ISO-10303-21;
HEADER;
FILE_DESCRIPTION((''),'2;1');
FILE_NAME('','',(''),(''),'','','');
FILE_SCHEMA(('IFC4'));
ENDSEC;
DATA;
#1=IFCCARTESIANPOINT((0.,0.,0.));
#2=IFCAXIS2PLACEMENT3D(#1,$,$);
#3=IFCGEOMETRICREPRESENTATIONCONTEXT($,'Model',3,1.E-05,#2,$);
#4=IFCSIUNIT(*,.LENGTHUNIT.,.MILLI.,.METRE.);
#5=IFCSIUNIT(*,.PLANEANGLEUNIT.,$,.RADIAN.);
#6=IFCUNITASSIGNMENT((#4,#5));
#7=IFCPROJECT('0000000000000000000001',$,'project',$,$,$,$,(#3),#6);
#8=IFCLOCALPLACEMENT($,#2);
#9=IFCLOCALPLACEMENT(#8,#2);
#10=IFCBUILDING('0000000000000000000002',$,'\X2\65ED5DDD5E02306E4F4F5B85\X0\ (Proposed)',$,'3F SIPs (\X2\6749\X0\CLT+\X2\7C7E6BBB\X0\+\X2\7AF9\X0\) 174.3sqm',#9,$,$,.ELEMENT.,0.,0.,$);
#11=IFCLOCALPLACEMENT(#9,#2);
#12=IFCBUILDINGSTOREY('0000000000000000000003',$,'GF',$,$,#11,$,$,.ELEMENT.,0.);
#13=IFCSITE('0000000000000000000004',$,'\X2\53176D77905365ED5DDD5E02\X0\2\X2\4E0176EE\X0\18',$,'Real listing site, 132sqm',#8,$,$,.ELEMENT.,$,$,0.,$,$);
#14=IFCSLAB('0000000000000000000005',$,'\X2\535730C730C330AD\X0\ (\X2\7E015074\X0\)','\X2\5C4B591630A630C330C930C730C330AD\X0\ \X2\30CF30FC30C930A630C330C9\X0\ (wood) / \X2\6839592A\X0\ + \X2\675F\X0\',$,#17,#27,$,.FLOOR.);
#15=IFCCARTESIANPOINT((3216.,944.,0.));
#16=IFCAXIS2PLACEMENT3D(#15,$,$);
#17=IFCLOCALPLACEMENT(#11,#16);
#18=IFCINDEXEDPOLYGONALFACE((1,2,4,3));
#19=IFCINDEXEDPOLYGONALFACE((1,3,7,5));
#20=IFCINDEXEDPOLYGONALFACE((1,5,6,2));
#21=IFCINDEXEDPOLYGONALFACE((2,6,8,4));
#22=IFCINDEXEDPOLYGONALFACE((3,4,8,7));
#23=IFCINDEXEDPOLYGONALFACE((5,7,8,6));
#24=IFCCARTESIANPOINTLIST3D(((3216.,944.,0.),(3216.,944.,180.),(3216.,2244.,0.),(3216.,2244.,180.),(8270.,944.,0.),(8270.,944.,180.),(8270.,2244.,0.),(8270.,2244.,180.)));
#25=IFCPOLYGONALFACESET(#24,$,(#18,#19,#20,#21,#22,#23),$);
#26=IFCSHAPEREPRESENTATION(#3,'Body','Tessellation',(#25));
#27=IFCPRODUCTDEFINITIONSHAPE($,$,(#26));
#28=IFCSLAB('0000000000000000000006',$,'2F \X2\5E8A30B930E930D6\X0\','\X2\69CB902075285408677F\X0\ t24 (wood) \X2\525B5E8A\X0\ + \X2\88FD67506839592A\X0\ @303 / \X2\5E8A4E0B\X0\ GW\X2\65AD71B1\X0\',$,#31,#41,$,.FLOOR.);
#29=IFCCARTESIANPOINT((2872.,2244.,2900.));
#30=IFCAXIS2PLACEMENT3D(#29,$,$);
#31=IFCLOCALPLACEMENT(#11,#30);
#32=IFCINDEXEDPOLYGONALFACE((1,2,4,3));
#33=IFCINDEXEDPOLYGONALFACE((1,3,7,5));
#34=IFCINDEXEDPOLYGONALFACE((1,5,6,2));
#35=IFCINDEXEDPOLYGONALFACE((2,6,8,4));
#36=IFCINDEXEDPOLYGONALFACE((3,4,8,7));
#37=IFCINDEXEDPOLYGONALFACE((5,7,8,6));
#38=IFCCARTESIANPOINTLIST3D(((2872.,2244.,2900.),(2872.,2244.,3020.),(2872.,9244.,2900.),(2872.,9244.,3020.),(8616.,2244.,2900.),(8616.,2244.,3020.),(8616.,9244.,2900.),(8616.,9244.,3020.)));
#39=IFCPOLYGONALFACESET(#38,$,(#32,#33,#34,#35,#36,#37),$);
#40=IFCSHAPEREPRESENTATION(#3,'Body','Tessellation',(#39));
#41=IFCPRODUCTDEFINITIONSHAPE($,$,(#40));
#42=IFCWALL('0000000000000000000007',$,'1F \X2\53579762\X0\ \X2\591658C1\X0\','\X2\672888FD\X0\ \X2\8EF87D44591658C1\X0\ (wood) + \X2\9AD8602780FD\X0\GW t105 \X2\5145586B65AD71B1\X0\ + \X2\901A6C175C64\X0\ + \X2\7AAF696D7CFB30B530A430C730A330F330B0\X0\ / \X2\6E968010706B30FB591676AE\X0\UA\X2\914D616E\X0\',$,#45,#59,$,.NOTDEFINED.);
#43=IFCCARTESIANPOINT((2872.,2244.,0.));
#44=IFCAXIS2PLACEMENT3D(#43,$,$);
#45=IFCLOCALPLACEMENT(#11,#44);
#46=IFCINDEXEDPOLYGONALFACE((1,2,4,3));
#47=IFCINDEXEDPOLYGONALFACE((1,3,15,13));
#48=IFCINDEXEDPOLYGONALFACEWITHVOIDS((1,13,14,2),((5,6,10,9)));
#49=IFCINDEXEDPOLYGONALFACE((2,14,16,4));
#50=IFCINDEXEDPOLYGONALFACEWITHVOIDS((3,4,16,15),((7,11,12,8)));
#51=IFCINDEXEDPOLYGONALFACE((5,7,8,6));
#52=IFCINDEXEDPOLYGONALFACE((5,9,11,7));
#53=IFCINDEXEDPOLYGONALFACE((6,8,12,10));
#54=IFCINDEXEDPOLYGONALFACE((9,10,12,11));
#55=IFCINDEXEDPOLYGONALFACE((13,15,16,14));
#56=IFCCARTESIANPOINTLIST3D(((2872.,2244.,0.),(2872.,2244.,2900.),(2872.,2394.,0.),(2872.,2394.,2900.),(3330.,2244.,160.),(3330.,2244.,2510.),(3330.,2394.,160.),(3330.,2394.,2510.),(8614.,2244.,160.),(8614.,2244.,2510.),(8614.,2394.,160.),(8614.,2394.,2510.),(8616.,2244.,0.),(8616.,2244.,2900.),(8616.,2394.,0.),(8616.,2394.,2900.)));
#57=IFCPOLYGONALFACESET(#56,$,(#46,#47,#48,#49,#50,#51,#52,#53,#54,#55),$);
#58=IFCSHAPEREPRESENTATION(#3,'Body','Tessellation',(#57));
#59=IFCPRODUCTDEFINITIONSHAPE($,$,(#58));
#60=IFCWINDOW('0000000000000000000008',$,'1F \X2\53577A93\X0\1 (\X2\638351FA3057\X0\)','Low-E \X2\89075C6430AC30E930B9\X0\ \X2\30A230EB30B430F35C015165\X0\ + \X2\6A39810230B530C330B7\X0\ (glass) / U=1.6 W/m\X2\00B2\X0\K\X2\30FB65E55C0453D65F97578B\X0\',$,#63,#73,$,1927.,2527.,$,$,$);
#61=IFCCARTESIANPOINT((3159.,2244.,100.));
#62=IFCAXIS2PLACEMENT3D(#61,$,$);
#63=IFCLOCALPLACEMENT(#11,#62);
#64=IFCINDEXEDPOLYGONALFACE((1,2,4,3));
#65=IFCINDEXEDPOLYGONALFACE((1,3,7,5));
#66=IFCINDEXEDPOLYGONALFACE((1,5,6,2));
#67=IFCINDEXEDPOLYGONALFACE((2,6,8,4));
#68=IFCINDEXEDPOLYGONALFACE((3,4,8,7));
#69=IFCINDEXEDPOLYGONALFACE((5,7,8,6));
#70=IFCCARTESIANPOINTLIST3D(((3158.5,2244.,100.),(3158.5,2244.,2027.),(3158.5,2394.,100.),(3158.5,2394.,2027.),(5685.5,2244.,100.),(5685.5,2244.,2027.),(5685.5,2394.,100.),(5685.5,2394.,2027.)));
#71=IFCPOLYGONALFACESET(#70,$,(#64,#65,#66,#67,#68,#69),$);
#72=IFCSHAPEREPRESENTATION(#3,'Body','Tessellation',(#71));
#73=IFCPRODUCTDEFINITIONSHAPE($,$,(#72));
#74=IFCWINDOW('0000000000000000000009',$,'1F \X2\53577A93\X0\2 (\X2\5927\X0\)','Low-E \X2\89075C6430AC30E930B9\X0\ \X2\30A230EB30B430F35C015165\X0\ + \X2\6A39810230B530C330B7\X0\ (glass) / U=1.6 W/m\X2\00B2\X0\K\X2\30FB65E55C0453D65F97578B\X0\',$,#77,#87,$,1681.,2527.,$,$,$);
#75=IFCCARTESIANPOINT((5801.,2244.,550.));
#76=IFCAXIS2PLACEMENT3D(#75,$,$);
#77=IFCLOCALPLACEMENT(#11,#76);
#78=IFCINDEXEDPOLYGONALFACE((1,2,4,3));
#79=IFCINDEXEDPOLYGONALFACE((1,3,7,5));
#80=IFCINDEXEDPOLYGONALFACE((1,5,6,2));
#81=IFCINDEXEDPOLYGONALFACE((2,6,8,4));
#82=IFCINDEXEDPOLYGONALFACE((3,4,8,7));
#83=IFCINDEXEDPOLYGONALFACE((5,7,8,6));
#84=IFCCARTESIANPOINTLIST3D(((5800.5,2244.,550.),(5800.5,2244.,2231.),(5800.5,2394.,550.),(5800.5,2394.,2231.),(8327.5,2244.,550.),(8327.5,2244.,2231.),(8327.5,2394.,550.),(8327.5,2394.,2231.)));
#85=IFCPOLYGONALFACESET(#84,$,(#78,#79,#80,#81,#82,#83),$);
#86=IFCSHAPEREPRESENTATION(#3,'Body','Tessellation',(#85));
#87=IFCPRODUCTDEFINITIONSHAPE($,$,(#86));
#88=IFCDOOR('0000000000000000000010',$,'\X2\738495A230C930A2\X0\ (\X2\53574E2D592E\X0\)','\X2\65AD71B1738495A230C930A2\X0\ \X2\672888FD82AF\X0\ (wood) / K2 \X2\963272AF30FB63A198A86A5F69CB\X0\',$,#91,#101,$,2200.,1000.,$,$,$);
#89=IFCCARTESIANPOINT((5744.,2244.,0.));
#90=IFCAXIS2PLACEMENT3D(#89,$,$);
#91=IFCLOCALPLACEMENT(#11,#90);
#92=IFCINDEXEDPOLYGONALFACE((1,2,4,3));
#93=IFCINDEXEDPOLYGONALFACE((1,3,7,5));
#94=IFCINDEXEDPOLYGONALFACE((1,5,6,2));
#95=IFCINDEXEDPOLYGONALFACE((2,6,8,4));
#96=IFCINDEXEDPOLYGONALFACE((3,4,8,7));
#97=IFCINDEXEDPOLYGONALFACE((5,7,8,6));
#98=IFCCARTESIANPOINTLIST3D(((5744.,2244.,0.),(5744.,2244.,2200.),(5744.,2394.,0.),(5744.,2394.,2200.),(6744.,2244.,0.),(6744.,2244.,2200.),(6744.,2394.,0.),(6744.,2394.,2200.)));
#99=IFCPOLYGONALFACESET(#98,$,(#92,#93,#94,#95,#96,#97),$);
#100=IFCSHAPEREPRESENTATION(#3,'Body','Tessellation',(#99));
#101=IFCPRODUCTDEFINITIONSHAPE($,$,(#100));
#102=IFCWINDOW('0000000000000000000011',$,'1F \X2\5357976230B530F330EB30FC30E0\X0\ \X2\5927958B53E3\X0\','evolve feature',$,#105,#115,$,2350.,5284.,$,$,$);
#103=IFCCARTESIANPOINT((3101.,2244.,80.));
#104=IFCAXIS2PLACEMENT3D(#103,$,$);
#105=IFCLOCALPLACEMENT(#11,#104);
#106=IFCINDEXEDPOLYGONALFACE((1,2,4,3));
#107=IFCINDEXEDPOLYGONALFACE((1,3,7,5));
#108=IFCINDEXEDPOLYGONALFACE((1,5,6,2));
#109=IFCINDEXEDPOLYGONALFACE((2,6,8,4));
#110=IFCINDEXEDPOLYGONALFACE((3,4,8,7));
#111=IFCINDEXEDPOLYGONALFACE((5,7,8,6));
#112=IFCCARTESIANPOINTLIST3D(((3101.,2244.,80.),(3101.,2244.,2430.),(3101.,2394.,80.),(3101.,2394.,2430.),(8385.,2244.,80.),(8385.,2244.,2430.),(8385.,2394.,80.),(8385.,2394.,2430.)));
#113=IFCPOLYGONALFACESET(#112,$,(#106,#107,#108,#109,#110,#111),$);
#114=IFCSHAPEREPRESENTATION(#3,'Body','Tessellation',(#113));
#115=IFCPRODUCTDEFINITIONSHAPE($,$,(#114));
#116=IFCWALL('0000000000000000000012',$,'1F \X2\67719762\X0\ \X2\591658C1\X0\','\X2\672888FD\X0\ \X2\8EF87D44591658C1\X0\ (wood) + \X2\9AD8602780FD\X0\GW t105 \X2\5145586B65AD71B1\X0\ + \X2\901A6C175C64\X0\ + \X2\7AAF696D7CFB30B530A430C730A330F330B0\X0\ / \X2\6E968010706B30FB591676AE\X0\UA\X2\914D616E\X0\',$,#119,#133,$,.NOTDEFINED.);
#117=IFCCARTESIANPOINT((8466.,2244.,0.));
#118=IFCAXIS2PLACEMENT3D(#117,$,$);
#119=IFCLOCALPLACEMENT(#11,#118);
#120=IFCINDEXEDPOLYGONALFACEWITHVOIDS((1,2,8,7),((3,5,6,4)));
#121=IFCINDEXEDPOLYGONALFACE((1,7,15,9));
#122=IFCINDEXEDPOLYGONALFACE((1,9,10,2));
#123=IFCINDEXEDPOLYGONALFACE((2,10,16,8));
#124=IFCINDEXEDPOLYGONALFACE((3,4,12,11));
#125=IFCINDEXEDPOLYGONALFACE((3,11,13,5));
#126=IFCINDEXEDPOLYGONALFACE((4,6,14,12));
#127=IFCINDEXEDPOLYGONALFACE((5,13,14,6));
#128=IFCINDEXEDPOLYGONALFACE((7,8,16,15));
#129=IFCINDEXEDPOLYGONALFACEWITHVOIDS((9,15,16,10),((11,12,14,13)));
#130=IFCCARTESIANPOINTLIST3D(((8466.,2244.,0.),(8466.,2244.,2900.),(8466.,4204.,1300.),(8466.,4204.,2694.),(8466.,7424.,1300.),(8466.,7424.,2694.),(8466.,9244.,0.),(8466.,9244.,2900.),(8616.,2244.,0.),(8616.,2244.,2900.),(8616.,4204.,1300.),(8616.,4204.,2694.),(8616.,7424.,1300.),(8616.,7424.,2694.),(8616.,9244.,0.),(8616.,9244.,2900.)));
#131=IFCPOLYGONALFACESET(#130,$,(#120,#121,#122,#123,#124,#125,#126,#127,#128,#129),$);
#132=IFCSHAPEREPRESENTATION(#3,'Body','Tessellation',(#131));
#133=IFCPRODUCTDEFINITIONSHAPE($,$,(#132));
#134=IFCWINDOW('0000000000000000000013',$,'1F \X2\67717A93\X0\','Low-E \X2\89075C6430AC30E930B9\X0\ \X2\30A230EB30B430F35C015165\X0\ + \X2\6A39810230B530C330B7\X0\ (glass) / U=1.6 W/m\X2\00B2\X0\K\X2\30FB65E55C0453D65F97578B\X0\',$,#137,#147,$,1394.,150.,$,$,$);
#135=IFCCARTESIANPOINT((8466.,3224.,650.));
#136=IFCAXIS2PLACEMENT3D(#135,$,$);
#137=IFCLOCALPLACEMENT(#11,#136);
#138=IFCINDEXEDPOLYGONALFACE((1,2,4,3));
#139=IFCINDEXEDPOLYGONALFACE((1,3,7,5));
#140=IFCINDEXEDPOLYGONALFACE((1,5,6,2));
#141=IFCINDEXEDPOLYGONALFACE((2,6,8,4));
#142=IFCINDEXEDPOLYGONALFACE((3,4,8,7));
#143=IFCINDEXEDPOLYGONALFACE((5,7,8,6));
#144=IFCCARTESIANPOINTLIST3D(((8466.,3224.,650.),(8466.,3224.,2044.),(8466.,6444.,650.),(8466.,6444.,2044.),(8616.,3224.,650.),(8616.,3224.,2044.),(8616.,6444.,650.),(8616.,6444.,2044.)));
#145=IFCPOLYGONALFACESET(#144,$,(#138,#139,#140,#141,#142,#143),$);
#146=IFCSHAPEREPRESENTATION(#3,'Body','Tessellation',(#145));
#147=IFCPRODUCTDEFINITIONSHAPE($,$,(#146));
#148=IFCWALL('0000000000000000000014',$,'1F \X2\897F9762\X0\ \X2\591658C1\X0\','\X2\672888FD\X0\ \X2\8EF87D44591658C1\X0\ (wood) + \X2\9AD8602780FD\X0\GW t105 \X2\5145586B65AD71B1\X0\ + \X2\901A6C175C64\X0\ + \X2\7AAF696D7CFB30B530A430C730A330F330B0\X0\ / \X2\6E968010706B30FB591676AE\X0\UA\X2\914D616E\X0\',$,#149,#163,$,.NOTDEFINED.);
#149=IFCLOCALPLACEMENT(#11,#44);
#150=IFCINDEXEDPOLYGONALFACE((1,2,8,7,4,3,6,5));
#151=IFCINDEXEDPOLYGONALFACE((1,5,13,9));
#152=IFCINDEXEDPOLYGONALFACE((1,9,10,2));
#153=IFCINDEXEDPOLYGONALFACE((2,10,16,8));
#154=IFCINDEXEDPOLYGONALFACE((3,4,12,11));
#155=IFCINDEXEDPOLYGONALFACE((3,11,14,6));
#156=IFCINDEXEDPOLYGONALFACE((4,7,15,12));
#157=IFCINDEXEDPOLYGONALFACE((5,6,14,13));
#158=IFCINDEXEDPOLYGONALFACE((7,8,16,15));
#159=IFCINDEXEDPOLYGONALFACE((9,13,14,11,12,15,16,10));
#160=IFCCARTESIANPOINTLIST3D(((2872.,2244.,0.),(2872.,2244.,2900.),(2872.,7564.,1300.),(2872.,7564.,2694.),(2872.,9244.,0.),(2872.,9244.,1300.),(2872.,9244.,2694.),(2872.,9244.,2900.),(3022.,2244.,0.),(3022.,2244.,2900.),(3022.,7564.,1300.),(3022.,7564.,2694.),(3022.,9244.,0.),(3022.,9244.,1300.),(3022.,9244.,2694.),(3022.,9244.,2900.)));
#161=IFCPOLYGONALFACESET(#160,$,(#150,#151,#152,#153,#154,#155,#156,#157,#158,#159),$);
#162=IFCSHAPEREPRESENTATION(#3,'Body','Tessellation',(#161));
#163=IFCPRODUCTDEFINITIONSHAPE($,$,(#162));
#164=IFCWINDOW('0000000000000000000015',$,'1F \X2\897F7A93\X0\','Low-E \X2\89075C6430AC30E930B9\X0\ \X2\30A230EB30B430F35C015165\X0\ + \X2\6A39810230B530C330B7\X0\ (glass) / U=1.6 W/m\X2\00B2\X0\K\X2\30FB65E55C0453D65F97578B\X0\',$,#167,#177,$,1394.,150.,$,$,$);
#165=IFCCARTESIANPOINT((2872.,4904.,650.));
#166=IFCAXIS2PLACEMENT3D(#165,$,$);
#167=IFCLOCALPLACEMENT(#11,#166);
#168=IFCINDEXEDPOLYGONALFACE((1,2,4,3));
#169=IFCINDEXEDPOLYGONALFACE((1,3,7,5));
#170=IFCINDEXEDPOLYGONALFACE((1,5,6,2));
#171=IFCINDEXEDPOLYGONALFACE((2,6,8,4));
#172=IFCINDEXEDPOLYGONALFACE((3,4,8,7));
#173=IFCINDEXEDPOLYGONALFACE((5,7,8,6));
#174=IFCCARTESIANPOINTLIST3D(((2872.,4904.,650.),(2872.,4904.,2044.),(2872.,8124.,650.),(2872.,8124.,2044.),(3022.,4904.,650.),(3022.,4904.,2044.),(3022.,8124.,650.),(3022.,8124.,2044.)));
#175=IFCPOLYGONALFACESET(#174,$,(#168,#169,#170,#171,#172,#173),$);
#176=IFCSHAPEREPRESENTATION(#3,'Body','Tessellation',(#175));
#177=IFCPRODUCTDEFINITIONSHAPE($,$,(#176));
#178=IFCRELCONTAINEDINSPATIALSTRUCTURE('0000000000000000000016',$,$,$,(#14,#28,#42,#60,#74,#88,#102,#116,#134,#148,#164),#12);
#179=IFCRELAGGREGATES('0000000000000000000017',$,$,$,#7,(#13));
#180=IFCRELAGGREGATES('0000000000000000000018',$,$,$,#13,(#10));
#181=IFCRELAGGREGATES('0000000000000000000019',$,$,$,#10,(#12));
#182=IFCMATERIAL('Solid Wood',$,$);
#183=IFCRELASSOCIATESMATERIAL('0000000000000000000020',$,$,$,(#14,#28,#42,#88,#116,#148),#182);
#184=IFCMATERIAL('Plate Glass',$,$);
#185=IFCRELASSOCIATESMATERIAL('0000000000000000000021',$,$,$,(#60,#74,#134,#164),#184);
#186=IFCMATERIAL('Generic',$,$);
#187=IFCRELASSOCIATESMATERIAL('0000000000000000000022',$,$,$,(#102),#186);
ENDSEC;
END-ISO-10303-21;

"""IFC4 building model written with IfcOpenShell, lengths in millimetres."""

from ifc_helpers import new_model, si_unit, frame, frame_2d, origin, place, context, project, spatial, rectangle, extrude, material, element, fill, save


model = new_model("IFC4")

# Units and contexts
model_context = context("Model", 3, precision=1e-05, world=origin())
ifc_project = project(units=[si_unit("LENGTHUNIT", "METRE", prefix="MILLI"), si_unit("PLANEANGLEUNIT", "RADIAN")], contexts=[model_context])

# Site, building, storey
site_placement = place(None, origin())
site = spatial("IfcSite", under=ifc_project, at=site_placement, Name="北海道旭川市2丁目18", ObjectType="Real listing site, 132sqm", CompositionType="ELEMENT", RefElevation=0.0)
building_placement = place(site_placement, origin())
building = spatial("IfcBuilding", under=site, at=building_placement, Name="旭川市の住宅 (Proposed)", ObjectType="3F SIPs (杉CLT+籾殻+竹) 174.3sqm", CompositionType="ELEMENT", ElevationOfRefHeight=0.0, ElevationOfTerrain=0.0)
storey_placement = place(building_placement, origin())
storey = spatial("IfcBuildingStorey", under=building, at=storey_placement, Name="GF", CompositionType="ELEMENT", Elevation=0.0)

# Slabs
ifc_material_1 = material(Name="Solid Wood")
slab_1_placement = place(storey_placement, frame((3216.0, 944.0, 0.0)))
element("IfcSlab", 1, at=slab_1_placement, inside=storey, material=ifc_material_1, Name="南デッキ (縁側)", Description="屋外ウッドデッキ ハードウッド (wood) / 根太 + 束", PredefinedType="FLOOR", context=model_context, shape_type="SweptSolid", body=[
    extrude(rectangle(XDim=5054.0, YDim=1300.0, at=frame_2d((2527.0, 650.0))), frame((3216.0, 944.0, 0.0)), (0.0, 0.0, 1.0), 180.0),
])
slab_2_placement = place(storey_placement, frame((2872.0, 2244.0, 2900.0)))
element("IfcSlab", 2, at=slab_2_placement, inside=storey, material=ifc_material_1, Name="2F 床スラブ", Description="構造用合板 t24 (wood) 剛床 + 製材根太 @303 / 床下 GW断熱", PredefinedType="FLOOR", context=model_context, shape_type="SweptSolid", body=[
    extrude(rectangle(XDim=5744.0, YDim=7000.0, at=frame_2d((2872.0, 3500.0))), frame((2872.0, 2244.0, 2900.0)), (0.0, 0.0, 1.0), 120.0),
])
ifc_material_2 = material(Name="Generic")

# Wall, openings, windows, door
wall_1_placement = place(storey_placement, frame((2872.0, 2244.0, 0.0)))
wall_1 = element("IfcWall", 3, at=wall_1_placement, inside=storey, material=ifc_material_1, Name="1F 南面 外壁", Description="木製 軸組外壁 (wood) + 高性能GW t105 充填断熱 + 通気層 + 窯業系サイディング / 準耐火・外皮UA配慮", PredefinedType="NOTDEFINED", context=model_context, shape_type="SweptSolid", body=[
    extrude(rectangle(XDim=5744.0, YDim=150.0, at=frame_2d((2872.0, 75.0))), frame((2872.0, 2244.0, 0.0)), (0.0, 0.0, 1.0), 2900.0),
])
opening_1_placement = place(storey_placement, frame((3159.0, 2244.0, 100.0)))
opening_1 = element("IfcOpeningElement", 4, at=opening_1_placement, cuts=wall_1, PredefinedType="NOTDEFINED", context=model_context, shape_type="SweptSolid", body=[
    extrude(rectangle(XDim=2527.0, YDim=150.0, at=frame_2d((1263.0, 75.0))), frame((3159.0, 2244.0, 100.0)), (0.0, 0.0, 1.0), 1927.0),
])
opening_2_placement = place(storey_placement, frame((5801.0, 2244.0, 550.0)))
opening_2 = element("IfcOpeningElement", 5, at=opening_2_placement, cuts=wall_1, PredefinedType="NOTDEFINED", context=model_context, shape_type="SweptSolid", body=[
    extrude(rectangle(XDim=2527.0, YDim=150.0, at=frame_2d((1263.0, 75.0))), frame((5801.0, 2244.0, 550.0)), (0.0, 0.0, 1.0), 1681.0),
])
opening_3_placement = place(storey_placement, frame((5744.0, 2244.0, 0.0)))
opening_3 = element("IfcOpeningElement", 6, at=opening_3_placement, cuts=wall_1, PredefinedType="NOTDEFINED", context=model_context, shape_type="SweptSolid", body=[
    extrude(rectangle(XDim=1000.0, YDim=150.0, at=frame_2d((500.0, 75.0))), frame((5744.0, 2244.0, 0.0)), (0.0, 0.0, 1.0), 2200.0),
])
opening_4_placement = place(storey_placement, frame((3101.0, 2244.0, 80.0)))
opening_4 = element("IfcOpeningElement", 7, at=opening_4_placement, cuts=wall_1, PredefinedType="NOTDEFINED", context=model_context, shape_type="SweptSolid", body=[
    extrude(rectangle(XDim=5284.0, YDim=150.0, at=frame_2d((2642.0, 75.0))), frame((3101.0, 2244.0, 80.0)), (0.0, 0.0, 1.0), 2350.0),
])
ifc_material_3 = material(Name="Plate Glass")
window_1_placement = place(storey_placement, frame((3159.0, 2244.0, 100.0)))
window_1 = element("IfcWindow", 8, at=window_1_placement, inside=storey, material=ifc_material_3, Name="1F 南窓1 (掃出し)", Description="Low-E 複層ガラス アルゴン封入 + 樹脂サッシ (glass) / U=1.6 W/m²K・日射取得型", OverallHeight=1927.0, OverallWidth=2527.0, context=model_context, shape_type="SweptSolid", body=[
    extrude(rectangle(XDim=2527.0, YDim=150.0, at=frame_2d((1263.0, 75.0))), frame((3159.0, 2244.0, 100.0)), (0.0, 0.0, 1.0), 1927.0),
])
fill(opening_1, window_1)
window_2_placement = place(storey_placement, frame((5801.0, 2244.0, 550.0)))
window_2 = element("IfcWindow", 9, at=window_2_placement, inside=storey, material=ifc_material_3, Name="1F 南窓2 (大)", Description="Low-E 複層ガラス アルゴン封入 + 樹脂サッシ (glass) / U=1.6 W/m²K・日射取得型", OverallHeight=1681.0, OverallWidth=2527.0, context=model_context, shape_type="SweptSolid", body=[
    extrude(rectangle(XDim=2527.0, YDim=150.0, at=frame_2d((1263.0, 75.0))), frame((5801.0, 2244.0, 550.0)), (0.0, 0.0, 1.0), 1681.0),
])
fill(opening_2, window_2)
door_placement = place(storey_placement, frame((5744.0, 2244.0, 0.0)))
door = element("IfcDoor", 10, at=door_placement, inside=storey, material=ifc_material_1, Name="玄関ドア (南中央)", Description="断熱玄関ドア 木製芯 (wood) / K2 防犯・採風機構", OverallHeight=2200.0, OverallWidth=1000.0, context=model_context, shape_type="SweptSolid", body=[
    extrude(rectangle(XDim=1000.0, YDim=150.0, at=frame_2d((500.0, 75.0))), frame((5744.0, 2244.0, 0.0)), (0.0, 0.0, 1.0), 2200.0),
])
fill(opening_3, door)
window_3_placement = place(storey_placement, frame((3101.0, 2244.0, 80.0)))
window_3 = element("IfcWindow", 11, at=window_3_placement, inside=storey, material=ifc_material_2, Name="1F 南面サンルーム 大開口", Description="evolve feature", OverallHeight=2350.0, OverallWidth=5284.0, context=model_context, shape_type="SweptSolid", body=[
    extrude(rectangle(XDim=5284.0, YDim=150.0, at=frame_2d((2642.0, 75.0))), frame((3101.0, 2244.0, 80.0)), (0.0, 0.0, 1.0), 2350.0),
])
fill(opening_4, window_3)

# Walls, openings, windows
wall_2_placement = place(storey_placement, frame((8466.0, 2244.0, 0.0)))
wall_2 = element("IfcWall", 12, at=wall_2_placement, inside=storey, material=ifc_material_1, Name="1F 東面 外壁", Description="木製 軸組外壁 (wood) + 高性能GW t105 充填断熱 + 通気層 + 窯業系サイディング / 準耐火・外皮UA配慮", PredefinedType="NOTDEFINED", context=model_context, shape_type="SweptSolid", body=[
    extrude(rectangle(XDim=150.0, YDim=7000.0, at=frame_2d((75.0, 3500.0))), frame((8466.0, 2244.0, 0.0)), (0.0, 0.0, 1.0), 2900.0),
])
opening_5_placement = place(storey_placement, frame((8466.0, 3224.0, 650.0)))
opening_5 = element("IfcOpeningElement", 13, at=opening_5_placement, cuts=wall_2, PredefinedType="NOTDEFINED", context=model_context, shape_type="SweptSolid", body=[
    extrude(rectangle(XDim=150.0, YDim=3220.0, at=frame_2d((75.0, 1610.0))), frame((8466.0, 3224.0, 650.0)), (0.0, 0.0, 1.0), 1394.0),
])
window_4_placement = place(storey_placement, frame((8466.0, 3224.0, 650.0)))
window_4 = element("IfcWindow", 14, at=window_4_placement, inside=storey, material=ifc_material_3, Name="1F 東窓", Description="Low-E 複層ガラス アルゴン封入 + 樹脂サッシ (glass) / U=1.6 W/m²K・日射取得型", OverallHeight=1394.0, OverallWidth=150.0, context=model_context, shape_type="SweptSolid", body=[
    extrude(rectangle(XDim=150.0, YDim=3220.0, at=frame_2d((75.0, 1610.0))), frame((8466.0, 3224.0, 650.0)), (0.0, 0.0, 1.0), 1394.0),
])
fill(opening_5, window_4)
wall_3_placement = place(storey_placement, frame((2872.0, 2244.0, 0.0)))
wall_3 = element("IfcWall", 15, at=wall_3_placement, inside=storey, material=ifc_material_1, Name="1F 西面 外壁", Description="木製 軸組外壁 (wood) + 高性能GW t105 充填断熱 + 通気層 + 窯業系サイディング / 準耐火・外皮UA配慮", PredefinedType="NOTDEFINED", context=model_context, shape_type="SweptSolid", body=[
    extrude(rectangle(XDim=150.0, YDim=7000.0, at=frame_2d((75.0, 3500.0))), frame((2872.0, 2244.0, 0.0)), (0.0, 0.0, 1.0), 2900.0),
])
opening_6_placement = place(storey_placement, frame((2872.0, 4904.0, 650.0)))
opening_6 = element("IfcOpeningElement", 16, at=opening_6_placement, cuts=wall_3, PredefinedType="NOTDEFINED", context=model_context, shape_type="SweptSolid", body=[
    extrude(rectangle(XDim=150.0, YDim=3220.0, at=frame_2d((75.0, 1610.0))), frame((2872.0, 4904.0, 650.0)), (0.0, 0.0, 1.0), 1394.0),
])
window_5_placement = place(storey_placement, frame((2872.0, 4904.0, 650.0)))
window_5 = element("IfcWindow", 17, at=window_5_placement, inside=storey, material=ifc_material_3, Name="1F 西窓", Description="Low-E 複層ガラス アルゴン封入 + 樹脂サッシ (glass) / U=1.6 W/m²K・日射取得型", OverallHeight=1394.0, OverallWidth=150.0, context=model_context, shape_type="SweptSolid", body=[
    extrude(rectangle(XDim=150.0, YDim=3220.0, at=frame_2d((75.0, 1610.0))), frame((2872.0, 4904.0, 650.0)), (0.0, 0.0, 1.0), 1394.0),
])
fill(opening_6, window_5)

save(model, "model.ifc")
